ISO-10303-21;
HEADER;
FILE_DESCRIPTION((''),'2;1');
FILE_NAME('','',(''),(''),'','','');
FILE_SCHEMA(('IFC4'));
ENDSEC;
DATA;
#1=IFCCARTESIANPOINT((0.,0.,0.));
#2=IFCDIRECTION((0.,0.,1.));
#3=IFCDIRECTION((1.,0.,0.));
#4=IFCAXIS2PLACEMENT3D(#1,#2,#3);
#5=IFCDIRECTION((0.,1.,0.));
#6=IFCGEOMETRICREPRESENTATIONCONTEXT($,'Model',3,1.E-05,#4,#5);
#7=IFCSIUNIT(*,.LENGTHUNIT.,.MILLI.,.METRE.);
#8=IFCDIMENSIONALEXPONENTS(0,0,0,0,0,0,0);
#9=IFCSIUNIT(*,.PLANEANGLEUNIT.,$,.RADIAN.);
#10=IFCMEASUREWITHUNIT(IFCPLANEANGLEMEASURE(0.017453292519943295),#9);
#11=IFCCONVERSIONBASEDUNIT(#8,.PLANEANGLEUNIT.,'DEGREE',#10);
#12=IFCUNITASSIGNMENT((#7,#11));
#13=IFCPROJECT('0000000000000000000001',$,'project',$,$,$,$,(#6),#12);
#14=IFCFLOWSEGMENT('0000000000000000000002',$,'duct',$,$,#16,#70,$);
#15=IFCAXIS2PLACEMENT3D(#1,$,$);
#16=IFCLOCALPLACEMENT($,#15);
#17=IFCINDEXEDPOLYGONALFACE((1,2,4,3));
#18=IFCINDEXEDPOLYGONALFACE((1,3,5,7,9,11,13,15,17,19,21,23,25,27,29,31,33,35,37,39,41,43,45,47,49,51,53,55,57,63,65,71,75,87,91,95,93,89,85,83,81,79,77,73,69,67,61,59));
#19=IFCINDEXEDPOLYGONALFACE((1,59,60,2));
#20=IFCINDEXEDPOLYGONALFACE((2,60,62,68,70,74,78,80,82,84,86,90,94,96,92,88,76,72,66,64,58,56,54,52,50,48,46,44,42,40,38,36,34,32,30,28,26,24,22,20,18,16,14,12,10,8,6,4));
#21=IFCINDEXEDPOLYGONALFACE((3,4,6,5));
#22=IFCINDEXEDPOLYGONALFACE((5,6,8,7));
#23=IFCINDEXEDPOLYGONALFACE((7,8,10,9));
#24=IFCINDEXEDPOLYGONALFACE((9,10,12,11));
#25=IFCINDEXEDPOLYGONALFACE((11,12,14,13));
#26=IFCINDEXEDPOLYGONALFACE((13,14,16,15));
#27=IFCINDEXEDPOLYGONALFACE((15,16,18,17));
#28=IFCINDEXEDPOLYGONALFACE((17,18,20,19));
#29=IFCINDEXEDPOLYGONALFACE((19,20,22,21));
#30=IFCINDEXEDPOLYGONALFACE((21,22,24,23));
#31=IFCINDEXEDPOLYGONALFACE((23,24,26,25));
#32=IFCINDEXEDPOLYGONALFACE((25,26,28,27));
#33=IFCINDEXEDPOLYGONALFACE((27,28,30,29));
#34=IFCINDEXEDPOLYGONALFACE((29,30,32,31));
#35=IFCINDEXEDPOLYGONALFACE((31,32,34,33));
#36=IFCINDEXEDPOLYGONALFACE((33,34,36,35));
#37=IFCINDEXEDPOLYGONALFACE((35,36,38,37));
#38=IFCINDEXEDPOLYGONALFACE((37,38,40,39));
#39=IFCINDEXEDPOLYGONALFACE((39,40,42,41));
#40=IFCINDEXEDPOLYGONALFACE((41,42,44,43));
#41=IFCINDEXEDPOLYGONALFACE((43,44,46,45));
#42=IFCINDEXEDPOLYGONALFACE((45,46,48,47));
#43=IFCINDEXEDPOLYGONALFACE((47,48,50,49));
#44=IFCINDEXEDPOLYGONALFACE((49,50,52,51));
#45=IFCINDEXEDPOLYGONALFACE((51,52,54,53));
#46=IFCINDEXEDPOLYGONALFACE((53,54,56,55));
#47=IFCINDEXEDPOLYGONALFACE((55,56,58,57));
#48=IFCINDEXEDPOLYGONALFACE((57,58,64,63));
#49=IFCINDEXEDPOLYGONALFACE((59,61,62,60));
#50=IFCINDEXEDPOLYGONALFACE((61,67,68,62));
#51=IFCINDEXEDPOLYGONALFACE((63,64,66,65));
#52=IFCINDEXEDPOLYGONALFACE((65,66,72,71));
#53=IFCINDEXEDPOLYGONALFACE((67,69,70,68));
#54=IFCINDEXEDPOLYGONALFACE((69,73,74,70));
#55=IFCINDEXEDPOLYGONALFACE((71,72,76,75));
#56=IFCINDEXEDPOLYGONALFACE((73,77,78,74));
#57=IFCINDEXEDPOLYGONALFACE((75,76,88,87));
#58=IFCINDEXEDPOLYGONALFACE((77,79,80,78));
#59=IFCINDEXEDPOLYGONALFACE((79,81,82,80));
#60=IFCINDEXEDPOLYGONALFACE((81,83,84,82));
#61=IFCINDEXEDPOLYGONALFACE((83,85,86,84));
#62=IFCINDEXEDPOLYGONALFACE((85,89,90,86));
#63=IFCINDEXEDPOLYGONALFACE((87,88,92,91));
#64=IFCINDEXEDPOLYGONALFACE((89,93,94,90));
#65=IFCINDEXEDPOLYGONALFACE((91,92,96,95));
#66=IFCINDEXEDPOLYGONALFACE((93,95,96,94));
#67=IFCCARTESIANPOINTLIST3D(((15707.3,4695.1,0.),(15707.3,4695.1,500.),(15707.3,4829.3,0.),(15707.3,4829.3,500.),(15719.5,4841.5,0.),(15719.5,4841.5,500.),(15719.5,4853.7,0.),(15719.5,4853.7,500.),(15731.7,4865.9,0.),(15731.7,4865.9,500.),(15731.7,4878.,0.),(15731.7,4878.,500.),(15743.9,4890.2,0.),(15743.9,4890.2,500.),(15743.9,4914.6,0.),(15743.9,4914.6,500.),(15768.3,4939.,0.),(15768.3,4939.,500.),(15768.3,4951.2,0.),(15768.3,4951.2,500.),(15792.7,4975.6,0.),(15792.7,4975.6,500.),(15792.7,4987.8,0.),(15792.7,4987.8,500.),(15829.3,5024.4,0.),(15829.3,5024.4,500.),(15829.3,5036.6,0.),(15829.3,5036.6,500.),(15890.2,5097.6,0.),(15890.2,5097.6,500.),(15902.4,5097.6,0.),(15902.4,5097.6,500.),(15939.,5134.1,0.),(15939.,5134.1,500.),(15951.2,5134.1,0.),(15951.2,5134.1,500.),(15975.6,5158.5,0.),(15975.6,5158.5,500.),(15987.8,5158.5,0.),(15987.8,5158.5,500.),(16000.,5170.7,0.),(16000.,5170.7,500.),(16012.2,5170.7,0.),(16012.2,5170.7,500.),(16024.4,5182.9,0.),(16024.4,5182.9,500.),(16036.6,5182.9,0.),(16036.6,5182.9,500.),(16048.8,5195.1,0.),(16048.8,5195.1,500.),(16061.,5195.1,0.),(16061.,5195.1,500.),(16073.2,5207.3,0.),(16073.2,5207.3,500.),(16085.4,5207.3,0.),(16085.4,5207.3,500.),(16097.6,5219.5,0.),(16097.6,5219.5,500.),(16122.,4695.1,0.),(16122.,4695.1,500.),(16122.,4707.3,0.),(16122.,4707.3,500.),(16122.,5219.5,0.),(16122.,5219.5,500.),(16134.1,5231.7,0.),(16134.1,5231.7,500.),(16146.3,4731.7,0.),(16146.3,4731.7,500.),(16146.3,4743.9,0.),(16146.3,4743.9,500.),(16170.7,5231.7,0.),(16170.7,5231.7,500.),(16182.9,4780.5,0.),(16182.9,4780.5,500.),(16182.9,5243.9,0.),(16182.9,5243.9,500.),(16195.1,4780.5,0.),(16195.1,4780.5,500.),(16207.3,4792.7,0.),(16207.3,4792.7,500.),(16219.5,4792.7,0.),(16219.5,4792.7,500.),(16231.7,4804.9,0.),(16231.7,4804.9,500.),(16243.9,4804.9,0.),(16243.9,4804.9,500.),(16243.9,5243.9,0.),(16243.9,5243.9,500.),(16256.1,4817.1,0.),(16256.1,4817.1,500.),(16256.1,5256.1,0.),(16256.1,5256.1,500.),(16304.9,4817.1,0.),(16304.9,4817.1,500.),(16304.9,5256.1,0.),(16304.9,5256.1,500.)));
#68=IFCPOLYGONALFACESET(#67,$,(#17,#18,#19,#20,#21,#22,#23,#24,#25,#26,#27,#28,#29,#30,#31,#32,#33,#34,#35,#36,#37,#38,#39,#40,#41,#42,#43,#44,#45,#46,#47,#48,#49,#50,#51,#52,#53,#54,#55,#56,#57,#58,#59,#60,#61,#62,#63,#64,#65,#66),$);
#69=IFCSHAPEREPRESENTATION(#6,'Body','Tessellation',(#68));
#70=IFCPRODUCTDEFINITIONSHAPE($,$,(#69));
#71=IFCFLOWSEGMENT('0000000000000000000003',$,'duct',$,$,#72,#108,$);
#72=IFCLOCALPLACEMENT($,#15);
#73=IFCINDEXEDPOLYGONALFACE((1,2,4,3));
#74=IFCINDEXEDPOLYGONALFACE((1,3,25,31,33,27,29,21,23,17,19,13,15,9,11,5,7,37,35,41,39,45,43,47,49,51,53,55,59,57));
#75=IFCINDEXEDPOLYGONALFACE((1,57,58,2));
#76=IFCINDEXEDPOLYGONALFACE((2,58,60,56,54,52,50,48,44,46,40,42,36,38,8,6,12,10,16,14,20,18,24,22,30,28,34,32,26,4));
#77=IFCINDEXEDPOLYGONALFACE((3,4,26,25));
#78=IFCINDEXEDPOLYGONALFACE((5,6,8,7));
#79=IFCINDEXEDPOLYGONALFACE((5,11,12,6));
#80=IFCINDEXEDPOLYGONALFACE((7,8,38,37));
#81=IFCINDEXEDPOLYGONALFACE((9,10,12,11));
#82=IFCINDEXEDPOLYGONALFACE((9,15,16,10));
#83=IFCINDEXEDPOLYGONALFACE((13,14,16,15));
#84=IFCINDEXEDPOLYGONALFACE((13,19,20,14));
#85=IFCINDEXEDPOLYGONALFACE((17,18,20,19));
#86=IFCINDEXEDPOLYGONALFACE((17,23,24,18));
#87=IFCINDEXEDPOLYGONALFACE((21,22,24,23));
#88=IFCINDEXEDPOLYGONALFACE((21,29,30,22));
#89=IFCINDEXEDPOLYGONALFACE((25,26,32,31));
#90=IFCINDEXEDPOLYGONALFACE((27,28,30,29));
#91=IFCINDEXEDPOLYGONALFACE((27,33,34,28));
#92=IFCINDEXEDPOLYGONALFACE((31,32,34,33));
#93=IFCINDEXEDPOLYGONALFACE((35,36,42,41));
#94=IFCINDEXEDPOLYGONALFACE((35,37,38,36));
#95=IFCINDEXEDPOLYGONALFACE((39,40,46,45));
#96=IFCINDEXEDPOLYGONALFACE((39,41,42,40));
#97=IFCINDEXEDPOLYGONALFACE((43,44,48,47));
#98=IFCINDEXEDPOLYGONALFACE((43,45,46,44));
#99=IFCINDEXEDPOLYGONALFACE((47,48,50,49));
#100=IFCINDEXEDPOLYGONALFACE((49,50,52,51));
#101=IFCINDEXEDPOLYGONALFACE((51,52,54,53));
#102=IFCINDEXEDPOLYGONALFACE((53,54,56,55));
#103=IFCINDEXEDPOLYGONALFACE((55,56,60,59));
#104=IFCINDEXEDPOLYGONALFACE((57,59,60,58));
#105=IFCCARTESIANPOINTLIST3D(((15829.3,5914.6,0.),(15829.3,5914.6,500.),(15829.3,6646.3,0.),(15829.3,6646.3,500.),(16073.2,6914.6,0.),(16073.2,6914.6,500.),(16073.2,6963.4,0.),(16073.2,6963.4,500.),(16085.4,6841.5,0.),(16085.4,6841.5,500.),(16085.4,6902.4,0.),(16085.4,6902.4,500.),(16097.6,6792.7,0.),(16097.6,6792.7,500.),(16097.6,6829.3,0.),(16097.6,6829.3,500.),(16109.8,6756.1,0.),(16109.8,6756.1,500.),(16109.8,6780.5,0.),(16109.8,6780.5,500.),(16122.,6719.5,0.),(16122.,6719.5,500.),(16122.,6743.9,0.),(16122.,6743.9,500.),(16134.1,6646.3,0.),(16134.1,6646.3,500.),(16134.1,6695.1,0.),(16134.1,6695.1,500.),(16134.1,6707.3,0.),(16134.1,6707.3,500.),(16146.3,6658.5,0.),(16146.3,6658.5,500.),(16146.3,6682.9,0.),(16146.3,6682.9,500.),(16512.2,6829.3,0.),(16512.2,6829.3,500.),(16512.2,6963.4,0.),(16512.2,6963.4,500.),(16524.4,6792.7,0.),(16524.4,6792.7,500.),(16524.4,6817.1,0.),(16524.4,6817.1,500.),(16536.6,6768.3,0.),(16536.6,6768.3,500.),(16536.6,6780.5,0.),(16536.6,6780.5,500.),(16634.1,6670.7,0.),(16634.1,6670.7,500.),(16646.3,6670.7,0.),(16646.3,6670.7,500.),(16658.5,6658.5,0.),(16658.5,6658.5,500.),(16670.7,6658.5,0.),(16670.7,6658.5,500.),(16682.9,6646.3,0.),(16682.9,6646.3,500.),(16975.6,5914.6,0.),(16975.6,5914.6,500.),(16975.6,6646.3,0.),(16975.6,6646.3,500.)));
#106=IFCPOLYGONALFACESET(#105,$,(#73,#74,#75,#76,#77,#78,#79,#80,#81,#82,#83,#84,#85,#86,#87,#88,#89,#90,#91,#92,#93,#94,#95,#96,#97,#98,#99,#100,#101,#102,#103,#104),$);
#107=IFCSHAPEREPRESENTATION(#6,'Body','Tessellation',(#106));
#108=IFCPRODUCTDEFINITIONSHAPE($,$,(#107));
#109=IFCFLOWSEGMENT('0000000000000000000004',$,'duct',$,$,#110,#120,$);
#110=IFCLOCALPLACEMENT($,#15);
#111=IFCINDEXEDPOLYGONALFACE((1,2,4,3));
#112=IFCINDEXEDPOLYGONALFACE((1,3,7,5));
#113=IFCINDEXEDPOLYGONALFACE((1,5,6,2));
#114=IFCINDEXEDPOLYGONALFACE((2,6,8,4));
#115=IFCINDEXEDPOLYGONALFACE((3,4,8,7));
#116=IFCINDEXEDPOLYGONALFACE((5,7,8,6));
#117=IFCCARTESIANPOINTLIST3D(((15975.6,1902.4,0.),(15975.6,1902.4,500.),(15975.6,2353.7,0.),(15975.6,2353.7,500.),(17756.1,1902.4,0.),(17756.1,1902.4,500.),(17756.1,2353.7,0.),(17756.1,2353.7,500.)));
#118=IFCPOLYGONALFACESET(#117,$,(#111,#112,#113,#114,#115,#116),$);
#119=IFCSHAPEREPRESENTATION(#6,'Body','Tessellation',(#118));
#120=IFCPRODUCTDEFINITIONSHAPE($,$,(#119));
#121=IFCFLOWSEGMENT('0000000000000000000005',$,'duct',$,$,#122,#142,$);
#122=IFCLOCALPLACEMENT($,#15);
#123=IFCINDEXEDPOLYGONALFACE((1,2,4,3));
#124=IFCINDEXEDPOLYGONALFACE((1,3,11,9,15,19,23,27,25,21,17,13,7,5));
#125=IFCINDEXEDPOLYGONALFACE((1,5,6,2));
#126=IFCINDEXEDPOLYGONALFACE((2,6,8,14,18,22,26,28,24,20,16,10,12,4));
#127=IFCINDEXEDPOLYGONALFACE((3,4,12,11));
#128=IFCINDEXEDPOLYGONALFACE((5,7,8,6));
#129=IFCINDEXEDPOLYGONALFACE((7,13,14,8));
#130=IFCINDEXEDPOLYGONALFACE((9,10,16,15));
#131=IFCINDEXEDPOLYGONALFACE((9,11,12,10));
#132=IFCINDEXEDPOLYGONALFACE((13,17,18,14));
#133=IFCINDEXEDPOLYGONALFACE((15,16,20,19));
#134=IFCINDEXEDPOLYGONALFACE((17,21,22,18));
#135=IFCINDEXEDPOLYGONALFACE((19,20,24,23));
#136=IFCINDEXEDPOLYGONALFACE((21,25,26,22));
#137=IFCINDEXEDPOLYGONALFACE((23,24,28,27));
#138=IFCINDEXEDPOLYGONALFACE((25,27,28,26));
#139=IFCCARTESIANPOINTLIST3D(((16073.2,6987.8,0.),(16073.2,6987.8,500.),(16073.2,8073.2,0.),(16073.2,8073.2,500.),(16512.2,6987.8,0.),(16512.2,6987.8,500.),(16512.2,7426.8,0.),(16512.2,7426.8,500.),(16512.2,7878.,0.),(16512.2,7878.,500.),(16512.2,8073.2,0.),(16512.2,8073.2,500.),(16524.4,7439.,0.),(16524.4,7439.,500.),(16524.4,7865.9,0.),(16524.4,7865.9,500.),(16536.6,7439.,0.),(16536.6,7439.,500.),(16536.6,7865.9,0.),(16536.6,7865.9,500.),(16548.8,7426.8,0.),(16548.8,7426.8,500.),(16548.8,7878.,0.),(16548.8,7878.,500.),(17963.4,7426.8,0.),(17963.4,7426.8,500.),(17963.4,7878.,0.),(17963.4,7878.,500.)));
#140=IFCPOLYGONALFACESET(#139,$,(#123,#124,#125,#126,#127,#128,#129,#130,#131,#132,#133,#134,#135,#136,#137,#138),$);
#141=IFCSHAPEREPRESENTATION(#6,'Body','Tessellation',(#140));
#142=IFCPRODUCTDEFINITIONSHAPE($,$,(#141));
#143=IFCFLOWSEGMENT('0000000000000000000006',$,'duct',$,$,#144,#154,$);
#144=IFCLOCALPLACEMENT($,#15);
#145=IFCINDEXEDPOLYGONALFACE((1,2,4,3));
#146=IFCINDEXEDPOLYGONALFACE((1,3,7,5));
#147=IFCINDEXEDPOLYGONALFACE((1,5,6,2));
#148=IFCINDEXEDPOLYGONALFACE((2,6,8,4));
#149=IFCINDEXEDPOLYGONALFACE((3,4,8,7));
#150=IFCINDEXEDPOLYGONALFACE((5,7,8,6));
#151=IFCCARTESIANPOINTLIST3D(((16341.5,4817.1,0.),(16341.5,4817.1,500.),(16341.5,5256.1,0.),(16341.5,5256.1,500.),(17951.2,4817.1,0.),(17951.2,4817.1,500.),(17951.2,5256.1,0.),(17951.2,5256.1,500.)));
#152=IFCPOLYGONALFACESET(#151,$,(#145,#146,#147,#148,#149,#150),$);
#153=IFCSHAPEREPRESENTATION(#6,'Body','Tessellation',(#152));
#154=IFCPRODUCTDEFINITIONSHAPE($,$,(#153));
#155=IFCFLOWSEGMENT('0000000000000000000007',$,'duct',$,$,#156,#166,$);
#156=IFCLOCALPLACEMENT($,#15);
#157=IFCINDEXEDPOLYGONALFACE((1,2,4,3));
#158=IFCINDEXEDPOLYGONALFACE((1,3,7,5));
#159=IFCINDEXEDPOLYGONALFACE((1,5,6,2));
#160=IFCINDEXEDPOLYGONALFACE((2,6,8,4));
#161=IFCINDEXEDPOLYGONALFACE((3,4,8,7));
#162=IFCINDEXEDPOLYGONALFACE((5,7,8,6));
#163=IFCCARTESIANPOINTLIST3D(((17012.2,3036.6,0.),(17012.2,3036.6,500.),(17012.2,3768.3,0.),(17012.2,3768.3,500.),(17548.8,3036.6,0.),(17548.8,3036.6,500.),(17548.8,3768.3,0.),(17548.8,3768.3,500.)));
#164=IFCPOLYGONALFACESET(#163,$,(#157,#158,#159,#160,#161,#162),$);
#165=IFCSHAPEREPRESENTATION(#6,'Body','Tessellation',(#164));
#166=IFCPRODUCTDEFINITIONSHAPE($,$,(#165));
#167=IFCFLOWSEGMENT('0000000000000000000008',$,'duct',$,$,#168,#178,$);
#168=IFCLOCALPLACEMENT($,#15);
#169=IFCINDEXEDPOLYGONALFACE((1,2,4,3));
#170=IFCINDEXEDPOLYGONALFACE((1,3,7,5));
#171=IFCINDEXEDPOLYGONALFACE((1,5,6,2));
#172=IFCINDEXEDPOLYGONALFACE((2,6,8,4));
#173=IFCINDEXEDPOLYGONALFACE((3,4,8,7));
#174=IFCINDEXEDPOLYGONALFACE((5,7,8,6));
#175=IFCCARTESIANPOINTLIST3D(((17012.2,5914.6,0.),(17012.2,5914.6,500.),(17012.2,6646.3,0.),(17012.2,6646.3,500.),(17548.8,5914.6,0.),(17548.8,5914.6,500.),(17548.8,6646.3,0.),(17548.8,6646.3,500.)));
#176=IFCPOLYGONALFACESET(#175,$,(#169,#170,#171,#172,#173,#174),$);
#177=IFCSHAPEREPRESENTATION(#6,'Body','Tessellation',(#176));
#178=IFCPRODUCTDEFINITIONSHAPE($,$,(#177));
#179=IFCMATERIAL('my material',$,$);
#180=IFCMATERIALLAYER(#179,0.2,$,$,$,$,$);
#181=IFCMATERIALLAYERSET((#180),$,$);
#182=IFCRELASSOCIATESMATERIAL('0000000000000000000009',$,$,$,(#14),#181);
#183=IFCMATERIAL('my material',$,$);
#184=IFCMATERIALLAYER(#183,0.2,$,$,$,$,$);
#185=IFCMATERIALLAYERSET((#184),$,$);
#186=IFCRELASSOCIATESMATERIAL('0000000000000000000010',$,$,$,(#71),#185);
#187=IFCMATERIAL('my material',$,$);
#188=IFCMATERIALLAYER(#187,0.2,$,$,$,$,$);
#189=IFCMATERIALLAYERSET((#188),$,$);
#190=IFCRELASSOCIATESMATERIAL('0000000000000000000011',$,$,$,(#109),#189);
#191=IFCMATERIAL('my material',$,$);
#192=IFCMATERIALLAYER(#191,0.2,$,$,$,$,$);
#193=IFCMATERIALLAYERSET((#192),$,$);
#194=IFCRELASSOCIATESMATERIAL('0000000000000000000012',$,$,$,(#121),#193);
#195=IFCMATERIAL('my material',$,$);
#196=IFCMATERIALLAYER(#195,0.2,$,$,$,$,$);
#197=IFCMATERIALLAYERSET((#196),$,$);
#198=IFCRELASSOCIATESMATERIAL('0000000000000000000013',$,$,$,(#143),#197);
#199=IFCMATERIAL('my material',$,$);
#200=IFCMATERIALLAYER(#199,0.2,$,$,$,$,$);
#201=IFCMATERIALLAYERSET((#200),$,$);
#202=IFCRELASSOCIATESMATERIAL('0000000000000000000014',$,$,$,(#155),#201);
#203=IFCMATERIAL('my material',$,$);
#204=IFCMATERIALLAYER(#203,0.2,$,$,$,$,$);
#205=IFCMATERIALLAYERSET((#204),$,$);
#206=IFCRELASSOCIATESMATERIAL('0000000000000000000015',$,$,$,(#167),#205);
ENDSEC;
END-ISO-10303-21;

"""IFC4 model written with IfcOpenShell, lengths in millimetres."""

from ifc_helpers import new_model, entity, si_unit, converted_unit, direction, origin_with_axes, place, context, project, polyline, outline, extrude, material, layer, layer_set, layer_usage, element, save


model = new_model("IFC4")

# Units and contexts
model_context = context("Model", 3, precision=1e-05, world=origin_with_axes(), true_north=direction((0.0, 1.0, 0.0)))
ifc_project = project(units=[si_unit("LENGTHUNIT", "METRE", prefix="MILLI"), converted_unit("PLANEANGLEUNIT", "DEGREE", entity("IfcPlaneAngleMeasure", 0.017453292519943295), si_unit("PLANEANGLEUNIT", "RADIAN"), dimensions=[0, 0, 0, 0, 0, 0, 0])], contexts=[model_context])

# Flow segments
ifc_material_1 = material(Name="my material")
ifc_layer_1 = layer(ifc_material_1, 0.2)
ifc_layer_set_1 = layer_set([ifc_layer_1])
ifc_layer_usage_1 = layer_usage(ifc_layer_set_1, "AXIS2", "POSITIVE", -0.1)
flow_segment_1_placement = place(None, origin_with_axes())
element("IfcFlowSegment", 1, at=flow_segment_1_placement, material=ifc_layer_usage_1, Name="duct", context=model_context, shape_type="SweptSolid", body=[
    extrude(outline(polyline([(15707.3, 4695.1), (16122.0, 4695.1), (16122.0, 4707.3), (16146.3, 4731.7), (16146.3, 4743.9), (16182.9, 4780.5), (16195.1, 4780.5), (16207.3, 4792.7), (16219.5, 4792.7), (16231.7, 4804.9), (16243.9, 4804.9), (16256.1, 4817.1), (16304.9, 4817.1), (16304.9, 5256.1), (16256.1, 5256.1), (16243.9, 5243.9), (16182.9, 5243.9), (16170.7, 5231.7), (16134.1, 5231.7), (16122.0, 5219.5), (16097.6, 5219.5), (16085.4, 5207.3), (16073.2, 5207.3), (16061.0, 5195.1), (16048.8, 5195.1), (16036.6, 5182.9), (16024.4, 5182.9), (16012.2, 5170.7), (16000.0, 5170.7), (15987.8, 5158.5), (15975.6, 5158.5), (15951.2, 5134.1), (15939.0, 5134.1), (15902.4, 5097.6), (15890.2, 5097.6), (15829.3, 5036.6), (15829.3, 5024.4), (15792.7, 4987.8), (15792.7, 4975.6), (15768.3, 4951.2), (15768.3, 4939.0), (15743.9, 4914.6), (15743.9, 4890.2), (15731.7, 4878.0), (15731.7, 4865.9), (15719.5, 4853.7), (15719.5, 4841.5), (15707.3, 4829.3), (15707.3, 4695.1)])), origin_with_axes(), (0.0, 0.0, 1.0), 500.0),
])
ifc_material_2 = material(Name="my material")
ifc_layer_2 = layer(ifc_material_2, 0.2)
ifc_layer_set_2 = layer_set([ifc_layer_2])
ifc_layer_usage_2 = layer_usage(ifc_layer_set_2, "AXIS2", "POSITIVE", -0.1)
flow_segment_2_placement = place(None, origin_with_axes())
element("IfcFlowSegment", 2, at=flow_segment_2_placement, material=ifc_layer_usage_2, Name="duct", context=model_context, shape_type="SweptSolid", body=[
    extrude(outline(polyline([(15829.3, 5914.6), (16975.6, 5914.6), (16975.6, 6646.3), (16682.9, 6646.3), (16670.7, 6658.5), (16658.5, 6658.5), (16646.3, 6670.7), (16634.1, 6670.7), (16536.6, 6768.3), (16536.6, 6780.5), (16524.4, 6792.7), (16524.4, 6817.1), (16512.2, 6829.3), (16512.2, 6963.4), (16073.2, 6963.4), (16073.2, 6914.6), (16085.4, 6902.4), (16085.4, 6841.5), (16097.6, 6829.3), (16097.6, 6792.7), (16109.8, 6780.5), (16109.8, 6756.1), (16122.0, 6743.9), (16122.0, 6719.5), (16134.1, 6707.3), (16134.1, 6695.1), (16146.3, 6682.9), (16146.3, 6658.5), (16134.1, 6646.3), (15829.3, 6646.3), (15829.3, 5914.6)])), origin_with_axes(), (0.0, 0.0, 1.0), 500.0),
])
ifc_material_3 = material(Name="my material")
ifc_layer_3 = layer(ifc_material_3, 0.2)
ifc_layer_set_3 = layer_set([ifc_layer_3])
ifc_layer_usage_3 = layer_usage(ifc_layer_set_3, "AXIS2", "POSITIVE", -0.1)
flow_segment_3_placement = place(None, origin_with_axes())
element("IfcFlowSegment", 3, at=flow_segment_3_placement, material=ifc_layer_usage_3, Name="duct", context=model_context, shape_type="SweptSolid", body=[
    extrude(outline(polyline([(15975.6, 1902.4), (17756.1, 1902.4), (17756.1, 2353.7), (15975.6, 2353.7), (15975.6, 1902.4)])), origin_with_axes(), (0.0, 0.0, 1.0), 500.0),
])
ifc_material_4 = material(Name="my material")
ifc_layer_4 = layer(ifc_material_4, 0.2)
ifc_layer_set_4 = layer_set([ifc_layer_4])
ifc_layer_usage_4 = layer_usage(ifc_layer_set_4, "AXIS2", "POSITIVE", -0.1)
flow_segment_4_placement = place(None, origin_with_axes())
element("IfcFlowSegment", 4, at=flow_segment_4_placement, material=ifc_layer_usage_4, Name="duct", context=model_context, shape_type="SweptSolid", body=[
    extrude(outline(polyline([(16073.2, 6987.8), (16512.2, 6987.8), (16512.2, 7426.8), (16524.4, 7439.0), (16536.6, 7439.0), (16548.8, 7426.8), (17963.4, 7426.8), (17963.4, 7878.0), (16548.8, 7878.0), (16536.6, 7865.9), (16524.4, 7865.9), (16512.2, 7878.0), (16512.2, 8073.2), (16073.2, 8073.2), (16073.2, 6987.8)])), origin_with_axes(), (0.0, 0.0, 1.0), 500.0),
])
ifc_material_5 = material(Name="my material")
ifc_layer_5 = layer(ifc_material_5, 0.2)
ifc_layer_set_5 = layer_set([ifc_layer_5])
ifc_layer_usage_5 = layer_usage(ifc_layer_set_5, "AXIS2", "POSITIVE", -0.1)
flow_segment_5_placement = place(None, origin_with_axes())
element("IfcFlowSegment", 5, at=flow_segment_5_placement, material=ifc_layer_usage_5, Name="duct", context=model_context, shape_type="SweptSolid", body=[
    extrude(outline(polyline([(16341.5, 4817.1), (17951.2, 4817.1), (17951.2, 5256.1), (16341.5, 5256.1), (16341.5, 4817.1)])), origin_with_axes(), (0.0, 0.0, 1.0), 500.0),
])
ifc_material_6 = material(Name="my material")
ifc_layer_6 = layer(ifc_material_6, 0.2)
ifc_layer_set_6 = layer_set([ifc_layer_6])
ifc_layer_usage_6 = layer_usage(ifc_layer_set_6, "AXIS2", "POSITIVE", -0.1)
flow_segment_6_placement = place(None, origin_with_axes())
element("IfcFlowSegment", 6, at=flow_segment_6_placement, material=ifc_layer_usage_6, Name="duct", context=model_context, shape_type="SweptSolid", body=[
    extrude(outline(polyline([(17012.2, 3036.6), (17548.8, 3036.6), (17548.8, 3768.3), (17012.2, 3768.3), (17012.2, 3036.6)])), origin_with_axes(), (0.0, 0.0, 1.0), 500.0),
])
ifc_material_7 = material(Name="my material")
ifc_layer_7 = layer(ifc_material_7, 0.2)
ifc_layer_set_7 = layer_set([ifc_layer_7])
ifc_layer_usage_7 = layer_usage(ifc_layer_set_7, "AXIS2", "POSITIVE", -0.1)
flow_segment_7_placement = place(None, origin_with_axes())
element("IfcFlowSegment", 7, at=flow_segment_7_placement, material=ifc_layer_usage_7, Name="duct", context=model_context, shape_type="SweptSolid", body=[
    extrude(outline(polyline([(17012.2, 5914.6), (17548.8, 5914.6), (17548.8, 6646.3), (17012.2, 6646.3), (17012.2, 5914.6)])), origin_with_axes(), (0.0, 0.0, 1.0), 500.0),
])

save(model, "model.ifc")
